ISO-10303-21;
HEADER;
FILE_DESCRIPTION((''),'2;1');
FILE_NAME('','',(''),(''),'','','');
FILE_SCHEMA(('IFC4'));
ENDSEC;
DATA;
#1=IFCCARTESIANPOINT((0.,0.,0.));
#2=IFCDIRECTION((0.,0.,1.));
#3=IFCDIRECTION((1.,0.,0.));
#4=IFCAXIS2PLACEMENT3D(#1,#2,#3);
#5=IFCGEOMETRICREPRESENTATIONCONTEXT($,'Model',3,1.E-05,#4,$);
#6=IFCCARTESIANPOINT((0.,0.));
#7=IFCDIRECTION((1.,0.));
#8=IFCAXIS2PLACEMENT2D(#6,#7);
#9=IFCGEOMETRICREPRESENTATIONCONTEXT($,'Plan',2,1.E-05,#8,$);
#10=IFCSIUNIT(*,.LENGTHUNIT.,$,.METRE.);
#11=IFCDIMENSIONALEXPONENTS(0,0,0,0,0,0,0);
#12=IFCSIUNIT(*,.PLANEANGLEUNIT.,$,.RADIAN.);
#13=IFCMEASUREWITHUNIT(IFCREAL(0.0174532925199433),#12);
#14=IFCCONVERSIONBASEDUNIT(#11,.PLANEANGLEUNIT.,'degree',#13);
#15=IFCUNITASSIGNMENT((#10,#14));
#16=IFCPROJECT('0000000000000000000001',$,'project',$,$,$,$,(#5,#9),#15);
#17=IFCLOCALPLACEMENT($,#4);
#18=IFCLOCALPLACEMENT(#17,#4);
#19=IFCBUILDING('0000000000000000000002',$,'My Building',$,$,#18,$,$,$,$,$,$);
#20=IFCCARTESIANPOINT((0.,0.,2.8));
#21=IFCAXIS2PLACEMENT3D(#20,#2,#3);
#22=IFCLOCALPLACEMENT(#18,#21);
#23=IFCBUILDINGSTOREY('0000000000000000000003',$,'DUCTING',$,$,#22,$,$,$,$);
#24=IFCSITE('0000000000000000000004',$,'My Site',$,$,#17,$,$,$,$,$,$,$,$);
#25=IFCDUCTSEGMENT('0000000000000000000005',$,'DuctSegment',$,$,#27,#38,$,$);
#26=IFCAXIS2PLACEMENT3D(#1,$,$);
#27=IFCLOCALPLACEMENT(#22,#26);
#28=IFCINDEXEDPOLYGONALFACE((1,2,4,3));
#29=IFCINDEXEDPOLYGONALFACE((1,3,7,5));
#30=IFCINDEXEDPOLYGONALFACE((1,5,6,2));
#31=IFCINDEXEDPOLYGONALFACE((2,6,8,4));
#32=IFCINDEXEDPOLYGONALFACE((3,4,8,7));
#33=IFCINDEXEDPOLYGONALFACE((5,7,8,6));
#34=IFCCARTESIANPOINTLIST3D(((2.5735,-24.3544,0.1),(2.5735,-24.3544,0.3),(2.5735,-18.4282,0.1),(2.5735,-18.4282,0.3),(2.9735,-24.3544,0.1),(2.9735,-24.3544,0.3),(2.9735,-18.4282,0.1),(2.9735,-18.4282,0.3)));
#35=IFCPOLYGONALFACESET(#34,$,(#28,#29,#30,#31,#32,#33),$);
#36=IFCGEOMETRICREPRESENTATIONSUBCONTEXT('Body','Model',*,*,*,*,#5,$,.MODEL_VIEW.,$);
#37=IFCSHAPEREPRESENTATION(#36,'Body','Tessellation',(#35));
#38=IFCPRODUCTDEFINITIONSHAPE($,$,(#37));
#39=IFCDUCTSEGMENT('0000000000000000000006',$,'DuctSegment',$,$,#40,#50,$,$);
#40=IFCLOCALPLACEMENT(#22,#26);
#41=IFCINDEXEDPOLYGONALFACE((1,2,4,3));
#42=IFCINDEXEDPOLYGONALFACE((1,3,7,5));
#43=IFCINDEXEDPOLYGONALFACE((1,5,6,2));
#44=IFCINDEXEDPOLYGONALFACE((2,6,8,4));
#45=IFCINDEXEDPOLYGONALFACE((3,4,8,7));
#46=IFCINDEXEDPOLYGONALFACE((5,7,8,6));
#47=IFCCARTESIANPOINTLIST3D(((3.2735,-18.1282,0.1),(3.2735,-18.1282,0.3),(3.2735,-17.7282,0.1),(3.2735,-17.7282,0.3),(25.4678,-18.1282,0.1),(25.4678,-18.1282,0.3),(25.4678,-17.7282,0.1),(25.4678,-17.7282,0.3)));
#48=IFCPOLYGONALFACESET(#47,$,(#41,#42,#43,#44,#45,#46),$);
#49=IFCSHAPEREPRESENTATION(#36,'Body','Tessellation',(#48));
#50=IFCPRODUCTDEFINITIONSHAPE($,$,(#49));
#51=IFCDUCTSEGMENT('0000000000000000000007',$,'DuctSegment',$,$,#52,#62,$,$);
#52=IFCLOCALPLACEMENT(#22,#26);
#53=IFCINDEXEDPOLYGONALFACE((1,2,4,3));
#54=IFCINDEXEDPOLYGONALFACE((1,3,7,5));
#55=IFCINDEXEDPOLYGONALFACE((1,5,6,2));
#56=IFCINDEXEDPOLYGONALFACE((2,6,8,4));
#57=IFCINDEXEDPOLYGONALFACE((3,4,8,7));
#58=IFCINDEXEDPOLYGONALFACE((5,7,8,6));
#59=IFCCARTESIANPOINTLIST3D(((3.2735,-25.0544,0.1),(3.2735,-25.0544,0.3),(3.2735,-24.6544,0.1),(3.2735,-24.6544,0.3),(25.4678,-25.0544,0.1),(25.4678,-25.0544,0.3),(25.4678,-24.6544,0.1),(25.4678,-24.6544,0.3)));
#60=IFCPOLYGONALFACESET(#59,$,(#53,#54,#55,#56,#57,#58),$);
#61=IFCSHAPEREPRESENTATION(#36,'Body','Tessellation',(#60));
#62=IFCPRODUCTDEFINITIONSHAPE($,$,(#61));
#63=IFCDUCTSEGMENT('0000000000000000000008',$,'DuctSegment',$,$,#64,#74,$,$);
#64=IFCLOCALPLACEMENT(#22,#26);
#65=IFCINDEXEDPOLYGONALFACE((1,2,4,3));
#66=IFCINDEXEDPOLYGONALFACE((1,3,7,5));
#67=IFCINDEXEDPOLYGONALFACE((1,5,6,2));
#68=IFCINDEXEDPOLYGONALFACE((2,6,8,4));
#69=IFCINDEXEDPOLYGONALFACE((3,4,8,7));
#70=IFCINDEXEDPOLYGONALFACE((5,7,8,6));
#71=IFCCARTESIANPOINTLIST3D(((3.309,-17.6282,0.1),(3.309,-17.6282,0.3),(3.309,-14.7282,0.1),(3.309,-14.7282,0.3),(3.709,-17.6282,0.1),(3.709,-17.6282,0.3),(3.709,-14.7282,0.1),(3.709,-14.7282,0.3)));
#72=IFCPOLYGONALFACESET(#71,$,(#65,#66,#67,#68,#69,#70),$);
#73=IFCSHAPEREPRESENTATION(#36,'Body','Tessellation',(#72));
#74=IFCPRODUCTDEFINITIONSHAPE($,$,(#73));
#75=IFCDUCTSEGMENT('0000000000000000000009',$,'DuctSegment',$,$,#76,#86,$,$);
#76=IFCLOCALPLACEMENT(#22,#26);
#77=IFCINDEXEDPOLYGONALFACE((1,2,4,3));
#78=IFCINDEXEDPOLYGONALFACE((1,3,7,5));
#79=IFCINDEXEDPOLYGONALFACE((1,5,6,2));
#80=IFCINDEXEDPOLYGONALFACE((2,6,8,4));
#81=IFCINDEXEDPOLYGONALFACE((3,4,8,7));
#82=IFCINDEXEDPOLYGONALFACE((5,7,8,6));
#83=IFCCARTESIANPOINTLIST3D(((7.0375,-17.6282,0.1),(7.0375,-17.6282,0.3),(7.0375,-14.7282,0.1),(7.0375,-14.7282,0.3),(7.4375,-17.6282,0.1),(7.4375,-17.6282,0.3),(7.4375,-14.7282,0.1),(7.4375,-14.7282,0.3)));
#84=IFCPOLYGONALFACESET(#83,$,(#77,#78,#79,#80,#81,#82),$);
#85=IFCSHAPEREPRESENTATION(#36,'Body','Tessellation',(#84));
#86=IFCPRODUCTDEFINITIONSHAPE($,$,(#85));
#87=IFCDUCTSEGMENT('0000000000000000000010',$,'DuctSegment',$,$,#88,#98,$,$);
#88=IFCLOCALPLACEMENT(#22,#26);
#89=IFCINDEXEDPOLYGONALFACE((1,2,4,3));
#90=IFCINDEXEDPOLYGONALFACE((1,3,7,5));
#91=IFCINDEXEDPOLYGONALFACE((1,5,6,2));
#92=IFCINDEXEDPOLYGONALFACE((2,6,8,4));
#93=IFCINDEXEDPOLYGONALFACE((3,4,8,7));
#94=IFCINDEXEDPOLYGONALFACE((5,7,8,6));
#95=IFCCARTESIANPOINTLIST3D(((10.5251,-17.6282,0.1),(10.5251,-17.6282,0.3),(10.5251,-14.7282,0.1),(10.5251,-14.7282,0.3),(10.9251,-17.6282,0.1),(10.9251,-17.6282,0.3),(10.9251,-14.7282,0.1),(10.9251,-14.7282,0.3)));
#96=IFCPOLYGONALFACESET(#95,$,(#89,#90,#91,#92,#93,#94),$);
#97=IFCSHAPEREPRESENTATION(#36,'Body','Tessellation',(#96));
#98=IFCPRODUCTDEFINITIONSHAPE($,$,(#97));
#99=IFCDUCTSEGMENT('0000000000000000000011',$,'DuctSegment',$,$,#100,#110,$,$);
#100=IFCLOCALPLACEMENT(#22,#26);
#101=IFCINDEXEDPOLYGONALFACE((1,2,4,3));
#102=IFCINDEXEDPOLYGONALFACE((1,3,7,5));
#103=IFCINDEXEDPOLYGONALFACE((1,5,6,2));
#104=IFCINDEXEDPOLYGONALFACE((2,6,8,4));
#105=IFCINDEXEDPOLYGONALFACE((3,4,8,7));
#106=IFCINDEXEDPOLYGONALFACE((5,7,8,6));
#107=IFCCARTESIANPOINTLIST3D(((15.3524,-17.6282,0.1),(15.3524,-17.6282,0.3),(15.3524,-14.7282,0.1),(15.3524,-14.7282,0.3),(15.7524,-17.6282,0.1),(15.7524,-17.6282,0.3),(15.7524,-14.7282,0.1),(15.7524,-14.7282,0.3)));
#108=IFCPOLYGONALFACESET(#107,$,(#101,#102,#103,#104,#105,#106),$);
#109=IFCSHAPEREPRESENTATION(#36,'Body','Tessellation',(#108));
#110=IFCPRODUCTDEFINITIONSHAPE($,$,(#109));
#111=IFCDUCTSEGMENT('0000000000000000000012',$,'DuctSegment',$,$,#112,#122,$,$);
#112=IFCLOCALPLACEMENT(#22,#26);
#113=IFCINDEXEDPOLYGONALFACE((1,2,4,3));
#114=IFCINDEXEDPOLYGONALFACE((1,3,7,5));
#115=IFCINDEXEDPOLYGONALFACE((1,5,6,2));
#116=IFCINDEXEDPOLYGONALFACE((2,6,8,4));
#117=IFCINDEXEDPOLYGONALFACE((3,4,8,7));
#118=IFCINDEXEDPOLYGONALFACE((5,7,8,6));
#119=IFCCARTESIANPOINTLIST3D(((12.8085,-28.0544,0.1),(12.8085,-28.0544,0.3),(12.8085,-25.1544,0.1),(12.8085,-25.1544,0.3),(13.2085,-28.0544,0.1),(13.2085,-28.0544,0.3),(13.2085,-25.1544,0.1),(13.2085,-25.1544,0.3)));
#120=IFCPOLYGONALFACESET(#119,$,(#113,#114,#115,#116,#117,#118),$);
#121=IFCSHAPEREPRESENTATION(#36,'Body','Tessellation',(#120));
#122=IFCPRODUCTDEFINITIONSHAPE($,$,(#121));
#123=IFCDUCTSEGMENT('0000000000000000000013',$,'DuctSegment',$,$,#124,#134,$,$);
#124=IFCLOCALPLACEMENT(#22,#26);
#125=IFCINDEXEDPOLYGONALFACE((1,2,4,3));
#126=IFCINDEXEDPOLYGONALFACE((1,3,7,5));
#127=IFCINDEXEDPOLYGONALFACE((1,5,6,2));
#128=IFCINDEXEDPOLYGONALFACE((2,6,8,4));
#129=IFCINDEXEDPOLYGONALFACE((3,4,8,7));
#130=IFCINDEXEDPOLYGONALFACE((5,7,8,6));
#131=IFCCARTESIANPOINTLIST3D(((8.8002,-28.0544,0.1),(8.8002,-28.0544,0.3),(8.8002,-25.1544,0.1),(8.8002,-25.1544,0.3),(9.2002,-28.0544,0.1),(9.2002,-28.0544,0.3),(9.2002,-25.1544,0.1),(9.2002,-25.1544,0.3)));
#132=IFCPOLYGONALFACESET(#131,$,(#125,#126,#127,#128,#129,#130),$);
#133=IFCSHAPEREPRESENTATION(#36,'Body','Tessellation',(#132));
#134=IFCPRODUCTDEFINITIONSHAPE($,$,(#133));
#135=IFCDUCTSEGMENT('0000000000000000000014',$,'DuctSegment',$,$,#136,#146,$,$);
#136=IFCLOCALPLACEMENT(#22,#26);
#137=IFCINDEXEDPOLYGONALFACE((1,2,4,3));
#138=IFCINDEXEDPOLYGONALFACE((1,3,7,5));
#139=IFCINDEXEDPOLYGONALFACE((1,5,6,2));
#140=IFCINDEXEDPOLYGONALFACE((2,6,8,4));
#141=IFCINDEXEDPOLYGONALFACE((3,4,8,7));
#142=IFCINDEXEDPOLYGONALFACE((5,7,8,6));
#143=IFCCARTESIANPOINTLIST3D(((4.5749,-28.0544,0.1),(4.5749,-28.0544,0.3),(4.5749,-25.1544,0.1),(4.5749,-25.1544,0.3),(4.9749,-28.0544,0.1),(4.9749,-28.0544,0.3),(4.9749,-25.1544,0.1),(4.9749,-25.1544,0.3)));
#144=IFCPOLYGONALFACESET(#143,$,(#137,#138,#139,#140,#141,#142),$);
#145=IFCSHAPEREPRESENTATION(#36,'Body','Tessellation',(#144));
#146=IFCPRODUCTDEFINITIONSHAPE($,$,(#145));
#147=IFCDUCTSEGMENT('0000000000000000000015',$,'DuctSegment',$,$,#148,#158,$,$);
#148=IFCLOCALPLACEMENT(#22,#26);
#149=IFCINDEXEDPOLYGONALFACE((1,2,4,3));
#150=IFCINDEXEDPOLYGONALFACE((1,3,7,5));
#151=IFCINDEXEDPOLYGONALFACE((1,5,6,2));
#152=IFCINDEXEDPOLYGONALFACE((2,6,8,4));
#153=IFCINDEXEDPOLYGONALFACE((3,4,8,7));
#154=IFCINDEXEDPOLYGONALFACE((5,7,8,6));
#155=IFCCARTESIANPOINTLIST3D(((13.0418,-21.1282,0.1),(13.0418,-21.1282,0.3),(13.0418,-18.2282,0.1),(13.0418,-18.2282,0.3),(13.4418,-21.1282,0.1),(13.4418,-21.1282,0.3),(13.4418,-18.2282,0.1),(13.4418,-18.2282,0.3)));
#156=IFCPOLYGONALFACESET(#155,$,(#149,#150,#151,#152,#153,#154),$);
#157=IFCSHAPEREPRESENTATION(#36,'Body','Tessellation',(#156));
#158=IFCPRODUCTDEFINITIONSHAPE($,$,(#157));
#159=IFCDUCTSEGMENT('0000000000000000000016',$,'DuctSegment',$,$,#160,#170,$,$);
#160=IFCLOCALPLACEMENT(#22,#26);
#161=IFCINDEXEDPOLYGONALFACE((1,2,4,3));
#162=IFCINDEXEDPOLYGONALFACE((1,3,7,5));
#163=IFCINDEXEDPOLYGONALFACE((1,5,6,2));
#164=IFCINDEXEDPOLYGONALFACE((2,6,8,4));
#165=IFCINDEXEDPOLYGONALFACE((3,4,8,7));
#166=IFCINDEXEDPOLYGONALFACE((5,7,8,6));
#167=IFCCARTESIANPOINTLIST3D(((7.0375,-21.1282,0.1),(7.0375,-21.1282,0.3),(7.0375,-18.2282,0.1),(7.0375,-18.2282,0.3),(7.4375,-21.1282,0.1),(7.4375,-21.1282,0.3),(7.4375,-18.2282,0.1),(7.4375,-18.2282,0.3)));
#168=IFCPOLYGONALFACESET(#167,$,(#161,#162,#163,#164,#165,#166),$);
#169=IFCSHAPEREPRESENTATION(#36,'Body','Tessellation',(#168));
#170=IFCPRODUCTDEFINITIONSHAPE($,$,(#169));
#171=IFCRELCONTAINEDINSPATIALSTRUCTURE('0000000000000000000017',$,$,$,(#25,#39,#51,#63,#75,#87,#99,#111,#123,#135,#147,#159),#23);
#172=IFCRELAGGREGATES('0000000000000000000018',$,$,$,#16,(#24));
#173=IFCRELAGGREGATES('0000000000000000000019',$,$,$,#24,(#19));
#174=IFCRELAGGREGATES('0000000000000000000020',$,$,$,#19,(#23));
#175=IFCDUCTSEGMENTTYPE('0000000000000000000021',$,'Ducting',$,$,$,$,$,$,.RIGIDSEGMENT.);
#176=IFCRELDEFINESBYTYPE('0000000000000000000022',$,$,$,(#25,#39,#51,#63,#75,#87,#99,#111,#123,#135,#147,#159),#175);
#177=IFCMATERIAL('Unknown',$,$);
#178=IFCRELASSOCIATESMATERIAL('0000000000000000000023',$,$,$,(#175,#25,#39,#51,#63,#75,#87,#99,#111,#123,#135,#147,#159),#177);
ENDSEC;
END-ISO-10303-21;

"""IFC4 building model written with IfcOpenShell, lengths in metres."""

from ifc_helpers import new_model, entity, si_unit, converted_unit, frame, origin_with_axes, origin_2d_with_axis, place, context, subcontext, project, spatial, rectangle, extrude, material, material_profile, profile_set, profile_usage, type_object, element, save


model = new_model("IFC4")

# Units and contexts
model_context = context("Model", 3, precision=1e-05, world=origin_with_axes())
plan_context = context("Plan", 2, precision=1e-05, world=origin_2d_with_axis())
body_context = subcontext(model_context, "Body", "Model", "MODEL_VIEW")
ifc_project = project(units=[si_unit("LENGTHUNIT", "METRE"), converted_unit("PLANEANGLEUNIT", "degree", entity("IfcReal", 0.0174532925199433), si_unit("PLANEANGLEUNIT", "RADIAN"), dimensions=[0, 0, 0, 0, 0, 0, 0])], contexts=[model_context, plan_context])

# Site, building, storey
site_placement = place(None, origin_with_axes())
site = spatial("IfcSite", under=ifc_project, at=site_placement, Name="My Site")
building_placement = place(site_placement, origin_with_axes())
building = spatial("IfcBuilding", under=site, at=building_placement, Name="My Building")
storey_placement = place(building_placement, frame((0.0, 0.0, 2.8), z_axis=(0.0, 0.0, 1.0), x_axis=(1.0, 0.0, 0.0)))
storey = spatial("IfcBuildingStorey", under=building, at=storey_placement, Name="DUCTING")

# Duct segments
ifc_material = material(Name="Unknown")
ifc_material_profile_1 = material_profile(ifc_material, rectangle(XDim=0.4, YDim=0.2))
ifc_profile_set_1 = profile_set([ifc_material_profile_1])
ifc_profile_usage_1 = profile_usage(ifc_profile_set_1, cardinal=5)
duct_segment_type = type_object("IfcDuctSegmentType", Name="Ducting", PredefinedType="RIGIDSEGMENT", material=ifc_profile_set_1)
duct_segment_1_placement = place(storey_placement, frame((2.7735, -18.4282, 0.2), z_axis=(0.0, -1.0, 0.0), x_axis=(1.0, 0.0, 0.0)))
element("IfcDuctSegment", 1, at=duct_segment_1_placement, inside=storey, type_object=duct_segment_type, material=ifc_profile_usage_1, Name="DuctSegment", context=body_context, shape_type="SweptSolid", body=[
    extrude(rectangle(XDim=0.4, YDim=0.2), origin_with_axes(), (0.0, 0.0, 1.0), 5.9263),
])
ifc_profile_usage_2 = profile_usage(ifc_profile_set_1, cardinal=5)
duct_segment_2_placement = place(storey_placement, frame((3.2735, -17.9282, 0.2), z_axis=(1.0, 0.0, 0.0), x_axis=(0.0, 1.0, 0.0)))
element("IfcDuctSegment", 2, at=duct_segment_2_placement, inside=storey, type_object=duct_segment_type, material=ifc_profile_usage_2, Name="DuctSegment", context=body_context, shape_type="SweptSolid", body=[
    extrude(rectangle(XDim=0.4, YDim=0.2), origin_with_axes(), (0.0, 0.0, 1.0), 22.1943),
])
ifc_profile_usage_3 = profile_usage(ifc_profile_set_1, cardinal=5)
duct_segment_3_placement = place(storey_placement, frame((3.2735, -24.8544, 0.2), z_axis=(1.0, 0.0, 0.0), x_axis=(0.0, 1.0, 0.0)))
element("IfcDuctSegment", 3, at=duct_segment_3_placement, inside=storey, type_object=duct_segment_type, material=ifc_profile_usage_3, Name="DuctSegment", context=body_context, shape_type="SweptSolid", body=[
    extrude(rectangle(XDim=0.4, YDim=0.2), origin_with_axes(), (0.0, 0.0, 1.0), 22.1943),
])
ifc_profile_usage_4 = profile_usage(ifc_profile_set_1, cardinal=5)
duct_segment_4_placement = place(storey_placement, frame((3.509, -14.7282, 0.2), z_axis=(0.0, -1.0, 0.0), x_axis=(1.0, 0.0, 0.0)))
element("IfcDuctSegment", 4, at=duct_segment_4_placement, inside=storey, type_object=duct_segment_type, material=ifc_profile_usage_4, Name="DuctSegment", context=body_context, shape_type="SweptSolid", body=[
    extrude(rectangle(XDim=0.4, YDim=0.2), origin_with_axes(), (0.0, 0.0, 1.0), 2.9),
])
ifc_profile_usage_5 = profile_usage(ifc_profile_set_1, cardinal=5)
duct_segment_5_placement = place(storey_placement, frame((7.2375, -14.7282, 0.2), z_axis=(0.0, -1.0, 0.0), x_axis=(1.0, 0.0, 0.0)))
element("IfcDuctSegment", 5, at=duct_segment_5_placement, inside=storey, type_object=duct_segment_type, material=ifc_profile_usage_5, Name="DuctSegment", context=body_context, shape_type="SweptSolid", body=[
    extrude(rectangle(XDim=0.4, YDim=0.2), origin_with_axes(), (0.0, 0.0, 1.0), 2.9),
])
ifc_profile_usage_6 = profile_usage(ifc_profile_set_1, cardinal=5)
duct_segment_6_placement = place(storey_placement, frame((10.7251, -14.7282, 0.2), z_axis=(0.0, -1.0, 0.0), x_axis=(1.0, 0.0, 0.0)))
element("IfcDuctSegment", 6, at=duct_segment_6_placement, inside=storey, type_object=duct_segment_type, material=ifc_profile_usage_6, Name="DuctSegment", context=body_context, shape_type="SweptSolid", body=[
    extrude(rectangle(XDim=0.4, YDim=0.2), origin_with_axes(), (0.0, 0.0, 1.0), 2.9),
])
ifc_profile_usage_7 = profile_usage(ifc_profile_set_1, cardinal=5)
duct_segment_7_placement = place(storey_placement, frame((15.5524, -14.7282, 0.2), z_axis=(0.0, -1.0, 0.0), x_axis=(1.0, 0.0, 0.0)))
element("IfcDuctSegment", 7, at=duct_segment_7_placement, inside=storey, type_object=duct_segment_type, material=ifc_profile_usage_7, Name="DuctSegment", context=body_context, shape_type="SweptSolid", body=[
    extrude(rectangle(XDim=0.4, YDim=0.2), origin_with_axes(), (0.0, 0.0, 1.0), 2.9),
])
ifc_profile_usage_8 = profile_usage(ifc_profile_set_1, cardinal=5)
duct_segment_8_placement = place(storey_placement, frame((13.0085, -28.0544, 0.2), z_axis=(0.000001, 1.0, 0.0), x_axis=(-1.0, 0.000001, 0.0)))
element("IfcDuctSegment", 8, at=duct_segment_8_placement, inside=storey, type_object=duct_segment_type, material=ifc_profile_usage_8, Name="DuctSegment", context=body_context, shape_type="SweptSolid", body=[
    extrude(rectangle(XDim=0.4, YDim=0.2), origin_with_axes(), (0.0, 0.0, 1.0), 2.9),
])
ifc_profile_usage_9 = profile_usage(ifc_profile_set_1, cardinal=5)
duct_segment_9_placement = place(storey_placement, frame((9.0002, -28.0544, 0.2), z_axis=(0.000001, 1.0, 0.0), x_axis=(-1.0, 0.000001, 0.0)))
element("IfcDuctSegment", 9, at=duct_segment_9_placement, inside=storey, type_object=duct_segment_type, material=ifc_profile_usage_9, Name="DuctSegment", context=body_context, shape_type="SweptSolid", body=[
    extrude(rectangle(XDim=0.4, YDim=0.2), origin_with_axes(), (0.0, 0.0, 1.0), 2.9),
])
ifc_profile_usage_10 = profile_usage(ifc_profile_set_1, cardinal=5)
duct_segment_10_placement = place(storey_placement, frame((4.7749, -28.0544, 0.2), z_axis=(0.000001, 1.0, 0.0), x_axis=(-1.0, 0.000001, 0.0)))
element("IfcDuctSegment", 10, at=duct_segment_10_placement, inside=storey, type_object=duct_segment_type, material=ifc_profile_usage_10, Name="DuctSegment", context=body_context, shape_type="SweptSolid", body=[
    extrude(rectangle(XDim=0.4, YDim=0.2), origin_with_axes(), (0.0, 0.0, 1.0), 2.9),
])
ifc_profile_usage_11 = profile_usage(ifc_profile_set_1, cardinal=5)
duct_segment_11_placement = place(storey_placement, frame((13.2418, -21.1282, 0.2), z_axis=(0.000001, 1.0, 0.0), x_axis=(-1.0, 0.000001, 0.0)))
element("IfcDuctSegment", 11, at=duct_segment_11_placement, inside=storey, type_object=duct_segment_type, material=ifc_profile_usage_11, Name="DuctSegment", context=body_context, shape_type="SweptSolid", body=[
    extrude(rectangle(XDim=0.4, YDim=0.2), origin_with_axes(), (0.0, 0.0, 1.0), 2.9),
])
ifc_profile_usage_12 = profile_usage(ifc_profile_set_1, cardinal=5)
duct_segment_12_placement = place(storey_placement, frame((7.2375, -21.1282, 0.2), z_axis=(0.000001, 1.0, 0.0), x_axis=(-1.0, 0.000001, 0.0)))
element("IfcDuctSegment", 12, at=duct_segment_12_placement, inside=storey, type_object=duct_segment_type, material=ifc_profile_usage_12, Name="DuctSegment", context=body_context, shape_type="SweptSolid", body=[
    extrude(rectangle(XDim=0.4, YDim=0.2), origin_with_axes(), (0.0, 0.0, 1.0), 2.9),
])

save(model, "model.ifc")
